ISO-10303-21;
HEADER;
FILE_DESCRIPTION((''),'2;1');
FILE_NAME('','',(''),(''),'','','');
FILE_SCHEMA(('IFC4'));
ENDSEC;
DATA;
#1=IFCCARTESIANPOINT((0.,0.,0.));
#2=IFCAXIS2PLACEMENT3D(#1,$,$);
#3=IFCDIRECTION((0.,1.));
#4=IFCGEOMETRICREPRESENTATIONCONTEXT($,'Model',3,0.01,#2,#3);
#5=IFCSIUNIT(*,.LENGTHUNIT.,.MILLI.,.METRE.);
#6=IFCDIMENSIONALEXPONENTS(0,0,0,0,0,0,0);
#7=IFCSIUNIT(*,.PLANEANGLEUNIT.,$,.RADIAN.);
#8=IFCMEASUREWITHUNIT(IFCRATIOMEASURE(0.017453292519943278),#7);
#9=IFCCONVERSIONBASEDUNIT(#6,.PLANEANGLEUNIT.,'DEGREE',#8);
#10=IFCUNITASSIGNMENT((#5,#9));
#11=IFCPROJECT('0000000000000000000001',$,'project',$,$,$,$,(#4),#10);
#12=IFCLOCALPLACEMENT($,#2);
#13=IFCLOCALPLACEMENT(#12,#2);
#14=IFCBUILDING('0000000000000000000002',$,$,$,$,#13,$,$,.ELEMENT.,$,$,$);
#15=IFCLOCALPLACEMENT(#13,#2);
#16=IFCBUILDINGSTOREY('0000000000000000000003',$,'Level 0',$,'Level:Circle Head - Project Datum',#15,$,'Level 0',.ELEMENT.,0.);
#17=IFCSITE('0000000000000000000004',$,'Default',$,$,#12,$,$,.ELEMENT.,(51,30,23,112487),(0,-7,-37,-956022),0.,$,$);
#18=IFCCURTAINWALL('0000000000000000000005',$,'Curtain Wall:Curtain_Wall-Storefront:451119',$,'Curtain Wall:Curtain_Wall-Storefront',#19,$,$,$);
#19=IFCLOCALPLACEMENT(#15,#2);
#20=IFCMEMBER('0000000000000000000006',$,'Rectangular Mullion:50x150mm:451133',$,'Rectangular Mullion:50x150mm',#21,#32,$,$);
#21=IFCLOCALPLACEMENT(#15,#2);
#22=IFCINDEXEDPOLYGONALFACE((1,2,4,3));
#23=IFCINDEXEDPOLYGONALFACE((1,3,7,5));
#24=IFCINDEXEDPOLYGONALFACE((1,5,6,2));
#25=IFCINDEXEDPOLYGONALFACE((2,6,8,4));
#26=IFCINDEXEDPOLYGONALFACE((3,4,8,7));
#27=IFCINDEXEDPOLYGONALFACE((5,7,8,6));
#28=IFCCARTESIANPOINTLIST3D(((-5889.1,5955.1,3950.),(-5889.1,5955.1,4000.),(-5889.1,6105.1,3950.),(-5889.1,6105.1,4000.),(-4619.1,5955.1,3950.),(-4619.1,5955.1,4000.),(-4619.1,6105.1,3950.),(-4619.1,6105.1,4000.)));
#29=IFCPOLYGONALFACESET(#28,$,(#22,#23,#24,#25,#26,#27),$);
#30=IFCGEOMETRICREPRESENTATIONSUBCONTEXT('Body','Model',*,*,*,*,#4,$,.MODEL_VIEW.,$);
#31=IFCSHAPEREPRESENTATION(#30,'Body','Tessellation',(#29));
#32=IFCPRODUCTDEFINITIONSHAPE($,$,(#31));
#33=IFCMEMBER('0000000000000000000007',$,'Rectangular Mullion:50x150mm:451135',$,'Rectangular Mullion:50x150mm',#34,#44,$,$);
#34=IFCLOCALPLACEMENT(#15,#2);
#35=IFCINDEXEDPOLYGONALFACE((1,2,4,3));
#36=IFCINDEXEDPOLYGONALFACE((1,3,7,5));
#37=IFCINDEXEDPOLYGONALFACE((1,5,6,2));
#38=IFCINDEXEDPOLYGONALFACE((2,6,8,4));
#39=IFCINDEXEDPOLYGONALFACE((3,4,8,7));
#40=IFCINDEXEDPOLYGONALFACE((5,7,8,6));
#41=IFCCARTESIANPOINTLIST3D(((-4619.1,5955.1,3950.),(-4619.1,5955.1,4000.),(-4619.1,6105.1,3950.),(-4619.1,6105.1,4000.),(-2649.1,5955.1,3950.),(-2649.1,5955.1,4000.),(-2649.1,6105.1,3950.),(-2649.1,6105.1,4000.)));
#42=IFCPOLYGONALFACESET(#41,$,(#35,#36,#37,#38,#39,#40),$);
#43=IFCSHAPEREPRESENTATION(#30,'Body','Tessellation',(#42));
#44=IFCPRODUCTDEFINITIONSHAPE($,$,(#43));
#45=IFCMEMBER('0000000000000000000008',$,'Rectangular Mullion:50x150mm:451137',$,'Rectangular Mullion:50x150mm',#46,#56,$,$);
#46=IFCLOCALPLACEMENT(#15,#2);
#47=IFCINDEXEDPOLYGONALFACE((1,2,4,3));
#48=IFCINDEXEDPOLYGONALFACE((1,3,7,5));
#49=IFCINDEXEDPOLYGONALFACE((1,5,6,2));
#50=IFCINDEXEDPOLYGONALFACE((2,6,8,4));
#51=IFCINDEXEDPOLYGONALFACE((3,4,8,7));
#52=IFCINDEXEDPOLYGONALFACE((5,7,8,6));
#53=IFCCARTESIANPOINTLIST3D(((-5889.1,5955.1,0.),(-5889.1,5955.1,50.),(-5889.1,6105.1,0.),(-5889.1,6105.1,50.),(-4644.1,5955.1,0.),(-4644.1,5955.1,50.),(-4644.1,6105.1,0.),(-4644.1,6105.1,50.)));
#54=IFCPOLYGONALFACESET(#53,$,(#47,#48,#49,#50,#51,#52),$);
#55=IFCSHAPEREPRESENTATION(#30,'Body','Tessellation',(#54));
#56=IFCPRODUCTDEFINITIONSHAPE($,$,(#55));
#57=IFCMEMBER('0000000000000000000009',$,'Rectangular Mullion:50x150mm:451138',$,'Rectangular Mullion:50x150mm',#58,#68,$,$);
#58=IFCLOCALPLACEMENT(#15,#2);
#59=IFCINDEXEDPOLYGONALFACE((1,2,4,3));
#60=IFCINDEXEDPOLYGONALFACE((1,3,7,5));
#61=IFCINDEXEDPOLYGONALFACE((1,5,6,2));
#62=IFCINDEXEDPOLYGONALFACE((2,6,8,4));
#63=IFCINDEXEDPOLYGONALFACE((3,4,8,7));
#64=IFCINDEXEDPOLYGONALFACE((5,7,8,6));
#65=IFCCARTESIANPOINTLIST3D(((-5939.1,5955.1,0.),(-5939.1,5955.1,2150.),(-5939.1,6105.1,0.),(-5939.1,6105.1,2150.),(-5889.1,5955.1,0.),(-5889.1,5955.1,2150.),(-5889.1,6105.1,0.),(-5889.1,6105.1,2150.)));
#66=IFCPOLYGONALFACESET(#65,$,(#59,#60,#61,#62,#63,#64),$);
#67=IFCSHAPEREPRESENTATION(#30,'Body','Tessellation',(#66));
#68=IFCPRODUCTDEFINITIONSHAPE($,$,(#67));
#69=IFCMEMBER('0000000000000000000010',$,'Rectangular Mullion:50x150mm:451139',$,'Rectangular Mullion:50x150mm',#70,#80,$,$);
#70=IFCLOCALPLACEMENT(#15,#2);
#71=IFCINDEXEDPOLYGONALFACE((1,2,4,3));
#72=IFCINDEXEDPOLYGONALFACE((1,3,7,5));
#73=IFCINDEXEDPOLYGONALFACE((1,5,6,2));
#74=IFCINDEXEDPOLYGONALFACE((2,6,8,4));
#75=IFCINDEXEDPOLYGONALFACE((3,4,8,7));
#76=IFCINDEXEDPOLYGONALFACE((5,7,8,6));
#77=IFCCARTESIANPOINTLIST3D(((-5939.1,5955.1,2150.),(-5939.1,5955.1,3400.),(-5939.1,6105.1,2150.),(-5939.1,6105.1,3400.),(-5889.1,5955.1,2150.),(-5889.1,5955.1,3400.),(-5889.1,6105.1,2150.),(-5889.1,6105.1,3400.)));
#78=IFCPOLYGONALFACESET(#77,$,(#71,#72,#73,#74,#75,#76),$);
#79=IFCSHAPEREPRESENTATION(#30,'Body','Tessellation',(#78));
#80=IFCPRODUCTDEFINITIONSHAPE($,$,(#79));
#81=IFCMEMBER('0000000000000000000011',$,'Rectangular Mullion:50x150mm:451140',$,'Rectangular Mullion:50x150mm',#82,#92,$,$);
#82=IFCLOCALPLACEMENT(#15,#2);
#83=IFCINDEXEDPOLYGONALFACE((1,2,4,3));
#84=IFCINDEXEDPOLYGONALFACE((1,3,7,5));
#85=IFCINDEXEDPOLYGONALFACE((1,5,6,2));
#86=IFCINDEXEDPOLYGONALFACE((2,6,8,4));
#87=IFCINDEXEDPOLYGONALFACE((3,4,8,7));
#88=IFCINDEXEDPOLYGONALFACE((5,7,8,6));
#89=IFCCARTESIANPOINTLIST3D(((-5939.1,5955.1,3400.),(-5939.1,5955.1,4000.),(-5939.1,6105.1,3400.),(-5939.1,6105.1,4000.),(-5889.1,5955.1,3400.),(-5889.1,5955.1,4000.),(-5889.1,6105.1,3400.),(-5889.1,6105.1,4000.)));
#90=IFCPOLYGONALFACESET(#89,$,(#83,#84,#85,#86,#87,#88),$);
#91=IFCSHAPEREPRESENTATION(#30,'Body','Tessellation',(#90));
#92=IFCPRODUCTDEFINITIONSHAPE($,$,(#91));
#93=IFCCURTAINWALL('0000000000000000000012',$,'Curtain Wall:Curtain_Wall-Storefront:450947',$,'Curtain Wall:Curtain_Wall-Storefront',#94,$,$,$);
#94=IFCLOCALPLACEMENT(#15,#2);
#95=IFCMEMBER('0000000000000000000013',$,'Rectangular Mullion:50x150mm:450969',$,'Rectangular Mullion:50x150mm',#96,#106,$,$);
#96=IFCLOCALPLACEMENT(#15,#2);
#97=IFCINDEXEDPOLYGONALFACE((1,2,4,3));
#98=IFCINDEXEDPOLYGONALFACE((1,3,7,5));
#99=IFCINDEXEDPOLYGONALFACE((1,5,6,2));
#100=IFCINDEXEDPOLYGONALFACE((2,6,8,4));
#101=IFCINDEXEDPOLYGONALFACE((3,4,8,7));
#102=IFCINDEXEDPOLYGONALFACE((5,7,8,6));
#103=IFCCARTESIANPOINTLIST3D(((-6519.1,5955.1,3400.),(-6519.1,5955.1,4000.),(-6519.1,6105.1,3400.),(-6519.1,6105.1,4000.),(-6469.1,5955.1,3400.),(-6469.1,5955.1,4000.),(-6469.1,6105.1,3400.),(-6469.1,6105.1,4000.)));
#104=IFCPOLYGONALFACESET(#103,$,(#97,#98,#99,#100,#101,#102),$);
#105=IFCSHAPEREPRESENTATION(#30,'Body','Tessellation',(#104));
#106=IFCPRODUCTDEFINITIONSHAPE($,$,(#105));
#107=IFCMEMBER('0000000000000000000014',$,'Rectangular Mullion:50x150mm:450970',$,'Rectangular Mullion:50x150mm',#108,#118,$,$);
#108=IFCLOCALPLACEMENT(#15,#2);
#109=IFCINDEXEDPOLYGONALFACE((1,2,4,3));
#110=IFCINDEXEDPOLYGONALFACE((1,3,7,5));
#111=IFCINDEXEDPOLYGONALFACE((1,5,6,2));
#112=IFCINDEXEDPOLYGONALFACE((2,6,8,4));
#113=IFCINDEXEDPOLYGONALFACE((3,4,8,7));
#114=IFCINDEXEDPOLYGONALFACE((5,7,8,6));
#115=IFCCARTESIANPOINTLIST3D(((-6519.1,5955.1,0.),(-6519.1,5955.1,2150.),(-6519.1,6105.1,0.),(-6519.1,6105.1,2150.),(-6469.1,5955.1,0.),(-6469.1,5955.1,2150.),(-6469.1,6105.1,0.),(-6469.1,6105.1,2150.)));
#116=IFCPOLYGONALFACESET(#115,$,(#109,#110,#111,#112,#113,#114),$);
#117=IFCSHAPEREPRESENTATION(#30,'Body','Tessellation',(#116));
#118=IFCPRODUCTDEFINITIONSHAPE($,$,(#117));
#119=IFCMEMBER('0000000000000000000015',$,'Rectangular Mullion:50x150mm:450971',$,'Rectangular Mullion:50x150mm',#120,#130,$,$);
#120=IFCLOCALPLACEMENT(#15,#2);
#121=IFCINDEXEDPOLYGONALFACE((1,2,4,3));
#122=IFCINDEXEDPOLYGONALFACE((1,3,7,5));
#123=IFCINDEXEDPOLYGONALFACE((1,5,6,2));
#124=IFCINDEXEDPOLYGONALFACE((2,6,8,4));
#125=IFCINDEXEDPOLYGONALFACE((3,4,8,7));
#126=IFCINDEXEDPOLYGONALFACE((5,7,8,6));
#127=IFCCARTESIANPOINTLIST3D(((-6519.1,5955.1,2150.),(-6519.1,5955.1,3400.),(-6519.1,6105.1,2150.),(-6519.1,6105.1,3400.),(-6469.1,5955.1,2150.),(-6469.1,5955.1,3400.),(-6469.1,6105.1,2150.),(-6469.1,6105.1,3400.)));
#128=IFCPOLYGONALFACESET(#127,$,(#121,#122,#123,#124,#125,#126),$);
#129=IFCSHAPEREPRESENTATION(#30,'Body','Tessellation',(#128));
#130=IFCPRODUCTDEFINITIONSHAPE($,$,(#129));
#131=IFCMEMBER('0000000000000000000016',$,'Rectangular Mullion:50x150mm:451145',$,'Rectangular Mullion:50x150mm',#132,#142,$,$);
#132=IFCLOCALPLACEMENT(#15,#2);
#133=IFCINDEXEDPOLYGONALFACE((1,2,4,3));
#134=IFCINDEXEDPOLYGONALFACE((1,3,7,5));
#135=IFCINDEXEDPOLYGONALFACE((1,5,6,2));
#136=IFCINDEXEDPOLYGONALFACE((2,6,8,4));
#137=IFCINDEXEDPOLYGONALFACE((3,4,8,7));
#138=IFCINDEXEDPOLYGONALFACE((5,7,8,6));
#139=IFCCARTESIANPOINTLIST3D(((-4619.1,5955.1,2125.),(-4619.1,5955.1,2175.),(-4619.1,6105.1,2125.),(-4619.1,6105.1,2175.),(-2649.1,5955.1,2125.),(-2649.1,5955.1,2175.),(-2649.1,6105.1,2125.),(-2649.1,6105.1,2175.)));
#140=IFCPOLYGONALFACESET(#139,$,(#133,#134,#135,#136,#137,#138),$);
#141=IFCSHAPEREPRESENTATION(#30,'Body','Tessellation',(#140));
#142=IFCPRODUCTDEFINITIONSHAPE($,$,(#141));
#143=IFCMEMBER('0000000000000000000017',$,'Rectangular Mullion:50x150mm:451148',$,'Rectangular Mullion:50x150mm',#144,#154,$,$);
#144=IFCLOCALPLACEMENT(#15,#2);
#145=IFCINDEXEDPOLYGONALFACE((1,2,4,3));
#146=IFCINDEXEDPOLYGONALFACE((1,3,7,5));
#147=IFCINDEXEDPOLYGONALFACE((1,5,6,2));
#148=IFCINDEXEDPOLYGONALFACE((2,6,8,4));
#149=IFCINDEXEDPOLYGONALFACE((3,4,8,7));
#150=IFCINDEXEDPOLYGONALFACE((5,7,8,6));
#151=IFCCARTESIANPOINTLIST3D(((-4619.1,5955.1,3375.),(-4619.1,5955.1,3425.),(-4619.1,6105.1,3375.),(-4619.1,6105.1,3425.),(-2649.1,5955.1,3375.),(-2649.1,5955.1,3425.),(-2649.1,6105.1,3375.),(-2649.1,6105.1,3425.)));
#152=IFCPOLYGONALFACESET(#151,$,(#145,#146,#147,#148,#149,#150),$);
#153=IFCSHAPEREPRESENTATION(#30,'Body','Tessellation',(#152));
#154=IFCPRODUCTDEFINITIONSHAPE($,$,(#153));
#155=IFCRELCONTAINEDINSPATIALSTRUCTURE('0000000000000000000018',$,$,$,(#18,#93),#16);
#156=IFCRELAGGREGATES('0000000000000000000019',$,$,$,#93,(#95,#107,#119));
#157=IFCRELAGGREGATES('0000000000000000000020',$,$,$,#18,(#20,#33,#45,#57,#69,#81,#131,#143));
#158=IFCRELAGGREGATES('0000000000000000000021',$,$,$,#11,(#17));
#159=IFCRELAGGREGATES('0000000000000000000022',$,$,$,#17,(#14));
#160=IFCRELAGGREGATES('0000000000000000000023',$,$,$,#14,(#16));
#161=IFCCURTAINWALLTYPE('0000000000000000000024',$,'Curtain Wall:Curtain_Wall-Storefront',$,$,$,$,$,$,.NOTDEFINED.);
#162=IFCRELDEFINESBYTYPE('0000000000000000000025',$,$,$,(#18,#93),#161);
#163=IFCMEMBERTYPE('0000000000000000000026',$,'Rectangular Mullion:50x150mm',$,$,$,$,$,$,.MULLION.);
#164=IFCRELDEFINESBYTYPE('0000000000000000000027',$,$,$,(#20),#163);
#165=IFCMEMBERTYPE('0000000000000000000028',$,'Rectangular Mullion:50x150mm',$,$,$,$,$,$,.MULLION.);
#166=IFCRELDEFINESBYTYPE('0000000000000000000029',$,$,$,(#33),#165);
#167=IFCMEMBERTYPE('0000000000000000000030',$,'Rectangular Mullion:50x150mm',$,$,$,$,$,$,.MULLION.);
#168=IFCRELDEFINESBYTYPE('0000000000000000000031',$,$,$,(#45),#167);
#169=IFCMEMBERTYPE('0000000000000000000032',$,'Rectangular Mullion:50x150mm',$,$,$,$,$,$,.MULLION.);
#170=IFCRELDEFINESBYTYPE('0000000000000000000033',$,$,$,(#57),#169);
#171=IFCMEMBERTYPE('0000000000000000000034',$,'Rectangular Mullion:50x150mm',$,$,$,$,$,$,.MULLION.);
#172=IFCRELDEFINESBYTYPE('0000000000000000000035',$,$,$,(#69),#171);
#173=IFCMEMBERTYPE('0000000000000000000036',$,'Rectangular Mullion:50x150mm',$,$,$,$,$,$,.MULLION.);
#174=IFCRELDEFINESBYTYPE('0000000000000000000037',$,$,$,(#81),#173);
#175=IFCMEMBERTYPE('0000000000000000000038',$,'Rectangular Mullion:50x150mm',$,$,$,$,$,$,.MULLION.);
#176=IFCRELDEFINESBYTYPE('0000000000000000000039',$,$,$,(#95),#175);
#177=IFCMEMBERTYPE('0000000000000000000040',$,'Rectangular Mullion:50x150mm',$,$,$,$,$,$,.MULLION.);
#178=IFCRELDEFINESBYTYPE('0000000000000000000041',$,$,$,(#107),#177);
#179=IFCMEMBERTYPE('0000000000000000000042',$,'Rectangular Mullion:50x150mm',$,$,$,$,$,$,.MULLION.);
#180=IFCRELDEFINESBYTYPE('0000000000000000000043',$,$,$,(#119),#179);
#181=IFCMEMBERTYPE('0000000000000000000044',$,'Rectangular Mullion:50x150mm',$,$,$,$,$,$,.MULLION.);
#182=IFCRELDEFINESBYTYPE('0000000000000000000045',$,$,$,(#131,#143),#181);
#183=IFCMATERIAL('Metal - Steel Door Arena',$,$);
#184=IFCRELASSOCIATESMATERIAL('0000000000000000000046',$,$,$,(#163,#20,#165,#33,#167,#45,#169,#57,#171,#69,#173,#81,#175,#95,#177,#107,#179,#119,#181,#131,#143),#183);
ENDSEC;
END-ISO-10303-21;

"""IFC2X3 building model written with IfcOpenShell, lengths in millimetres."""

from ifc_helpers import new_model, entity, si_unit, converted_unit, direction, frame, origin, origin_2d_with_axis, place, context, subcontext, project, spatial, rectangle, extrude, source, transform, mapped, material, type_object, type_shapes, element, aggregate, save


model = new_model("IFC2X3")

# Units and contexts
model_context = context("Model", 3, precision=0.01, world=origin(), true_north=direction((0.0, 1.0)))
body_context = subcontext(model_context, "Body", "Model", "MODEL_VIEW")
ifc_project = project(units=[si_unit("LENGTHUNIT", "METRE", prefix="MILLI"), converted_unit("PLANEANGLEUNIT", "DEGREE", entity("IfcRatioMeasure", 0.017453292519943278), si_unit("PLANEANGLEUNIT", "RADIAN"), dimensions=[0, 0, 0, 0, 0, 0, 0])], contexts=[model_context])

# Site, building, storey
site_placement = place(None, origin())
site = spatial("IfcSite", under=ifc_project, at=site_placement, Name="Default", CompositionType="ELEMENT", RefLatitude=(51, 30, 23, 112487), RefLongitude=(0, -7, -37, -956022), RefElevation=0.0)
building_placement = place(site_placement, origin())
building = spatial("IfcBuilding", under=site, at=building_placement, CompositionType="ELEMENT")
storey_placement = place(building_placement, origin())
storey = spatial("IfcBuildingStorey", under=building, at=storey_placement, Name="Level 0", ObjectType="Level:Circle Head - Project Datum", LongName="Level 0", CompositionType="ELEMENT", Elevation=0.0)

# Curtain walls, members
curtain_wall_type = type_object("IfcCurtainWallType", Name="Curtain Wall:Curtain_Wall-Storefront", PredefinedType="NOTDEFINED")
curtain_wall_1_placement = place(storey_placement, origin())
curtain_wall_1 = element("IfcCurtainWall", 1, at=curtain_wall_1_placement, inside=storey, type_object=curtain_wall_type, Name="Curtain Wall:Curtain_Wall-Storefront:451119", ObjectType="Curtain Wall:Curtain_Wall-Storefront")
ifc_material_1 = material(Name="Metal - Steel Door Arena")
member_type_1 = type_object("IfcMemberType", Name="Rectangular Mullion:50x150mm", PredefinedType="MULLION", material=ifc_material_1)
shared_shape_1 = source(origin(), body_context, "Body", "SweptSolid", [
    extrude(rectangle(XDim=150.0, YDim=50.0, at=origin_2d_with_axis()), frame((-25.0, 0.0, -1270.0), z_axis=(0.0, 0.0, 1.0), x_axis=(0.0, -1.0, 0.0)), (0.0, 0.0, 1.0), 1270.0),
])
type_shapes(member_type_1, [shared_shape_1])
member_1_placement = place(curtain_wall_1_placement, frame((-5889.1, 6030.1, 4000.0), z_axis=(-1.0, 0.0, 0.0), x_axis=(0.0, 0.0, 1.0)))
member_1 = element("IfcMember", 2, at=member_1_placement, type_object=member_type_1, material=ifc_material_1, Name="Rectangular Mullion:50x150mm:451133", ObjectType="Rectangular Mullion:50x150mm", context=body_context, shape_type="MappedRepresentation", body=[
    mapped(shared_shape_1, transform((0.0, 0.0, 0.0), scale=1.0)),
])
member_type_2 = type_object("IfcMemberType", Name="Rectangular Mullion:50x150mm", PredefinedType="MULLION", material=ifc_material_1)
shared_shape_2 = source(origin(), body_context, "Body", "SweptSolid", [
    extrude(rectangle(XDim=150.0, YDim=50.0, at=origin_2d_with_axis()), frame((-25.0, 0.0, -1970.0), z_axis=(0.0, 0.0, 1.0), x_axis=(0.0, -1.0, 0.0)), (0.0, 0.0, 1.0), 1970.0),
])
type_shapes(member_type_2, [shared_shape_2])
member_2_placement = place(curtain_wall_1_placement, frame((-4619.1, 6030.1, 4000.0), z_axis=(-1.0, 0.0, 0.0), x_axis=(0.0, 0.0, 1.0)))
member_2 = element("IfcMember", 3, at=member_2_placement, type_object=member_type_2, material=ifc_material_1, Name="Rectangular Mullion:50x150mm:451135", ObjectType="Rectangular Mullion:50x150mm", context=body_context, shape_type="MappedRepresentation", body=[
    mapped(shared_shape_2, transform((0.0, 0.0, 0.0), scale=1.0)),
])
member_type_3 = type_object("IfcMemberType", Name="Rectangular Mullion:50x150mm", PredefinedType="MULLION", material=ifc_material_1)
shared_shape_3 = source(origin(), body_context, "Body", "SweptSolid", [
    extrude(rectangle(XDim=150.0, YDim=50.0, at=origin_2d_with_axis()), frame((-25.0, 0.0, -1245.0), z_axis=(0.0, 0.0, 1.0), x_axis=(0.0, -1.0, 0.0)), (0.0, 0.0, 1.0), 1245.0),
])
type_shapes(member_type_3, [shared_shape_3])
member_3_placement = place(curtain_wall_1_placement, frame((-4644.1, 6030.1, 0.0), z_axis=(1.0, 0.0, 0.0), x_axis=(0.0, 0.0, -1.0)))
member_3 = element("IfcMember", 4, at=member_3_placement, type_object=member_type_3, material=ifc_material_1, Name="Rectangular Mullion:50x150mm:451137", ObjectType="Rectangular Mullion:50x150mm", context=body_context, shape_type="MappedRepresentation", body=[
    mapped(shared_shape_3, transform((0.0, 0.0, 0.0), scale=1.0)),
])
member_type_4 = type_object("IfcMemberType", Name="Rectangular Mullion:50x150mm", PredefinedType="MULLION", material=ifc_material_1)
shared_shape_4 = source(origin(), body_context, "Body", "SweptSolid", [
    extrude(rectangle(XDim=150.0, YDim=50.0, at=origin_2d_with_axis()), frame((-25.0, 0.0, -2150.0), z_axis=(0.0, 0.0, 1.0), x_axis=(0.0, -1.0, 0.0)), (0.0, 0.0, 1.0), 2150.0),
])
type_shapes(member_type_4, [shared_shape_4])
member_4_placement = place(curtain_wall_1_placement, frame((-5939.1, 6030.1, 0.0), z_axis=(0.0, 0.0, -1.0), x_axis=(-1.0, 0.0, 0.0)))
member_4 = element("IfcMember", 5, at=member_4_placement, type_object=member_type_4, material=ifc_material_1, Name="Rectangular Mullion:50x150mm:451138", ObjectType="Rectangular Mullion:50x150mm", context=body_context, shape_type="MappedRepresentation", body=[
    mapped(shared_shape_4, transform((0.0, 0.0, 0.0), scale=1.0)),
])
member_type_5 = type_object("IfcMemberType", Name="Rectangular Mullion:50x150mm", PredefinedType="MULLION", material=ifc_material_1)
shared_shape_5 = source(origin(), body_context, "Body", "SweptSolid", [
    extrude(rectangle(XDim=150.0, YDim=50.0, at=origin_2d_with_axis()), frame((-25.0, 0.0, -1250.0), z_axis=(0.0, 0.0, 1.0), x_axis=(0.0, -1.0, 0.0)), (0.0, 0.0, 1.0), 1250.0),
])
type_shapes(member_type_5, [shared_shape_5])
member_5_placement = place(curtain_wall_1_placement, frame((-5939.1, 6030.1, 2150.0), z_axis=(0.0, 0.0, -1.0), x_axis=(-1.0, 0.0, 0.0)))
member_5 = element("IfcMember", 6, at=member_5_placement, type_object=member_type_5, material=ifc_material_1, Name="Rectangular Mullion:50x150mm:451139", ObjectType="Rectangular Mullion:50x150mm", context=body_context, shape_type="MappedRepresentation", body=[
    mapped(shared_shape_5, transform((0.0, 0.0, 0.0), scale=1.0)),
])
member_type_6 = type_object("IfcMemberType", Name="Rectangular Mullion:50x150mm", PredefinedType="MULLION", material=ifc_material_1)
shared_shape_6 = source(origin(), body_context, "Body", "SweptSolid", [
    extrude(rectangle(XDim=150.0, YDim=50.0, at=origin_2d_with_axis()), frame((-25.0, 0.0, -600.0), z_axis=(0.0, 0.0, 1.0), x_axis=(0.0, -1.0, 0.0)), (0.0, 0.0, 1.0), 600.0),
])
type_shapes(member_type_6, [shared_shape_6])
member_6_placement = place(curtain_wall_1_placement, frame((-5939.1, 6030.1, 3400.0), z_axis=(0.0, 0.0, -1.0), x_axis=(-1.0, 0.0, 0.0)))
member_6 = element("IfcMember", 7, at=member_6_placement, type_object=member_type_6, material=ifc_material_1, Name="Rectangular Mullion:50x150mm:451140", ObjectType="Rectangular Mullion:50x150mm", context=body_context, shape_type="MappedRepresentation", body=[
    mapped(shared_shape_6, transform((0.0, 0.0, 0.0), scale=1.0)),
])
curtain_wall_2_placement = place(storey_placement, origin())
curtain_wall_2 = element("IfcCurtainWall", 8, at=curtain_wall_2_placement, inside=storey, type_object=curtain_wall_type, Name="Curtain Wall:Curtain_Wall-Storefront:450947", ObjectType="Curtain Wall:Curtain_Wall-Storefront")
member_type_7 = type_object("IfcMemberType", Name="Rectangular Mullion:50x150mm", PredefinedType="MULLION", material=ifc_material_1)
shared_shape_7 = source(origin(), body_context, "Body", "SweptSolid", [
    extrude(rectangle(XDim=150.0, YDim=50.0, at=origin_2d_with_axis()), frame((-25.0, 0.0, -600.0), z_axis=(0.0, 0.0, 1.0), x_axis=(0.0, -1.0, 0.0)), (0.0, 0.0, 1.0), 600.0),
])
type_shapes(member_type_7, [shared_shape_7])
member_7_placement = place(curtain_wall_2_placement, frame((-6469.1, 6030.1, 4000.0)))
member_7 = element("IfcMember", 9, at=member_7_placement, type_object=member_type_7, material=ifc_material_1, Name="Rectangular Mullion:50x150mm:450969", ObjectType="Rectangular Mullion:50x150mm", context=body_context, shape_type="MappedRepresentation", body=[
    mapped(shared_shape_7, transform((0.0, 0.0, 0.0), scale=1.0)),
])
member_type_8 = type_object("IfcMemberType", Name="Rectangular Mullion:50x150mm", PredefinedType="MULLION", material=ifc_material_1)
shared_shape_8 = source(origin(), body_context, "Body", "SweptSolid", [
    extrude(rectangle(XDim=150.0, YDim=50.0, at=origin_2d_with_axis()), frame((-25.0, 0.0, -2150.0), z_axis=(0.0, 0.0, 1.0), x_axis=(0.0, -1.0, 0.0)), (0.0, 0.0, 1.0), 2150.0),
])
type_shapes(member_type_8, [shared_shape_8])
member_8_placement = place(curtain_wall_2_placement, frame((-6469.1, 6030.1, 2150.0)))
member_8 = element("IfcMember", 10, at=member_8_placement, type_object=member_type_8, material=ifc_material_1, Name="Rectangular Mullion:50x150mm:450970", ObjectType="Rectangular Mullion:50x150mm", context=body_context, shape_type="MappedRepresentation", body=[
    mapped(shared_shape_8, transform((0.0, 0.0, 0.0), scale=1.0)),
])
member_type_9 = type_object("IfcMemberType", Name="Rectangular Mullion:50x150mm", PredefinedType="MULLION", material=ifc_material_1)
shared_shape_9 = source(origin(), body_context, "Body", "SweptSolid", [
    extrude(rectangle(XDim=150.0, YDim=50.0, at=origin_2d_with_axis()), frame((-25.0, 0.0, -1250.0), z_axis=(0.0, 0.0, 1.0), x_axis=(0.0, -1.0, 0.0)), (0.0, 0.0, 1.0), 1250.0),
])
type_shapes(member_type_9, [shared_shape_9])
member_9_placement = place(curtain_wall_2_placement, frame((-6469.1, 6030.1, 3400.0)))
member_9 = element("IfcMember", 11, at=member_9_placement, type_object=member_type_9, material=ifc_material_1, Name="Rectangular Mullion:50x150mm:450971", ObjectType="Rectangular Mullion:50x150mm", context=body_context, shape_type="MappedRepresentation", body=[
    mapped(shared_shape_9, transform((0.0, 0.0, 0.0), scale=1.0)),
])
aggregate(curtain_wall_2, [member_7, member_8, member_9])

# Members
member_type_10 = type_object("IfcMemberType", Name="Rectangular Mullion:50x150mm", PredefinedType="MULLION", material=ifc_material_1)
shared_shape_10 = source(origin(), body_context, "Body", "SweptSolid", [
    extrude(rectangle(XDim=150.0, YDim=50.0, at=origin_2d_with_axis()), frame((0.0, 0.0, -1970.0), z_axis=(0.0, 0.0, 1.0), x_axis=(0.0, -1.0, 0.0)), (0.0, 0.0, 1.0), 1970.0),
])
type_shapes(member_type_10, [shared_shape_10])
member_10_placement = place(curtain_wall_1_placement, frame((-4619.1, 6030.1, 2150.0), z_axis=(-1.0, 0.0, 0.0), x_axis=(0.0, 0.0, 1.0)))
member_10 = element("IfcMember", 12, at=member_10_placement, type_object=member_type_10, material=ifc_material_1, Name="Rectangular Mullion:50x150mm:451145", ObjectType="Rectangular Mullion:50x150mm", context=body_context, shape_type="MappedRepresentation", body=[
    mapped(shared_shape_10, transform((0.0, 0.0, 0.0), scale=1.0)),
])
member_11_placement = place(curtain_wall_1_placement, frame((-4619.1, 6030.1, 3400.0), z_axis=(-1.0, 0.0, 0.0), x_axis=(0.0, 0.0, 1.0)))
member_11 = element("IfcMember", 13, at=member_11_placement, type_object=member_type_10, material=ifc_material_1, Name="Rectangular Mullion:50x150mm:451148", ObjectType="Rectangular Mullion:50x150mm", context=body_context, shape_type="MappedRepresentation", body=[
    mapped(shared_shape_10, transform((0.0, 0.0, 0.0), scale=1.0)),
])

aggregate(curtain_wall_1, [member_1, member_2, member_3, member_4, member_5, member_6, member_10, member_11])

save(model, "model.ifc")
